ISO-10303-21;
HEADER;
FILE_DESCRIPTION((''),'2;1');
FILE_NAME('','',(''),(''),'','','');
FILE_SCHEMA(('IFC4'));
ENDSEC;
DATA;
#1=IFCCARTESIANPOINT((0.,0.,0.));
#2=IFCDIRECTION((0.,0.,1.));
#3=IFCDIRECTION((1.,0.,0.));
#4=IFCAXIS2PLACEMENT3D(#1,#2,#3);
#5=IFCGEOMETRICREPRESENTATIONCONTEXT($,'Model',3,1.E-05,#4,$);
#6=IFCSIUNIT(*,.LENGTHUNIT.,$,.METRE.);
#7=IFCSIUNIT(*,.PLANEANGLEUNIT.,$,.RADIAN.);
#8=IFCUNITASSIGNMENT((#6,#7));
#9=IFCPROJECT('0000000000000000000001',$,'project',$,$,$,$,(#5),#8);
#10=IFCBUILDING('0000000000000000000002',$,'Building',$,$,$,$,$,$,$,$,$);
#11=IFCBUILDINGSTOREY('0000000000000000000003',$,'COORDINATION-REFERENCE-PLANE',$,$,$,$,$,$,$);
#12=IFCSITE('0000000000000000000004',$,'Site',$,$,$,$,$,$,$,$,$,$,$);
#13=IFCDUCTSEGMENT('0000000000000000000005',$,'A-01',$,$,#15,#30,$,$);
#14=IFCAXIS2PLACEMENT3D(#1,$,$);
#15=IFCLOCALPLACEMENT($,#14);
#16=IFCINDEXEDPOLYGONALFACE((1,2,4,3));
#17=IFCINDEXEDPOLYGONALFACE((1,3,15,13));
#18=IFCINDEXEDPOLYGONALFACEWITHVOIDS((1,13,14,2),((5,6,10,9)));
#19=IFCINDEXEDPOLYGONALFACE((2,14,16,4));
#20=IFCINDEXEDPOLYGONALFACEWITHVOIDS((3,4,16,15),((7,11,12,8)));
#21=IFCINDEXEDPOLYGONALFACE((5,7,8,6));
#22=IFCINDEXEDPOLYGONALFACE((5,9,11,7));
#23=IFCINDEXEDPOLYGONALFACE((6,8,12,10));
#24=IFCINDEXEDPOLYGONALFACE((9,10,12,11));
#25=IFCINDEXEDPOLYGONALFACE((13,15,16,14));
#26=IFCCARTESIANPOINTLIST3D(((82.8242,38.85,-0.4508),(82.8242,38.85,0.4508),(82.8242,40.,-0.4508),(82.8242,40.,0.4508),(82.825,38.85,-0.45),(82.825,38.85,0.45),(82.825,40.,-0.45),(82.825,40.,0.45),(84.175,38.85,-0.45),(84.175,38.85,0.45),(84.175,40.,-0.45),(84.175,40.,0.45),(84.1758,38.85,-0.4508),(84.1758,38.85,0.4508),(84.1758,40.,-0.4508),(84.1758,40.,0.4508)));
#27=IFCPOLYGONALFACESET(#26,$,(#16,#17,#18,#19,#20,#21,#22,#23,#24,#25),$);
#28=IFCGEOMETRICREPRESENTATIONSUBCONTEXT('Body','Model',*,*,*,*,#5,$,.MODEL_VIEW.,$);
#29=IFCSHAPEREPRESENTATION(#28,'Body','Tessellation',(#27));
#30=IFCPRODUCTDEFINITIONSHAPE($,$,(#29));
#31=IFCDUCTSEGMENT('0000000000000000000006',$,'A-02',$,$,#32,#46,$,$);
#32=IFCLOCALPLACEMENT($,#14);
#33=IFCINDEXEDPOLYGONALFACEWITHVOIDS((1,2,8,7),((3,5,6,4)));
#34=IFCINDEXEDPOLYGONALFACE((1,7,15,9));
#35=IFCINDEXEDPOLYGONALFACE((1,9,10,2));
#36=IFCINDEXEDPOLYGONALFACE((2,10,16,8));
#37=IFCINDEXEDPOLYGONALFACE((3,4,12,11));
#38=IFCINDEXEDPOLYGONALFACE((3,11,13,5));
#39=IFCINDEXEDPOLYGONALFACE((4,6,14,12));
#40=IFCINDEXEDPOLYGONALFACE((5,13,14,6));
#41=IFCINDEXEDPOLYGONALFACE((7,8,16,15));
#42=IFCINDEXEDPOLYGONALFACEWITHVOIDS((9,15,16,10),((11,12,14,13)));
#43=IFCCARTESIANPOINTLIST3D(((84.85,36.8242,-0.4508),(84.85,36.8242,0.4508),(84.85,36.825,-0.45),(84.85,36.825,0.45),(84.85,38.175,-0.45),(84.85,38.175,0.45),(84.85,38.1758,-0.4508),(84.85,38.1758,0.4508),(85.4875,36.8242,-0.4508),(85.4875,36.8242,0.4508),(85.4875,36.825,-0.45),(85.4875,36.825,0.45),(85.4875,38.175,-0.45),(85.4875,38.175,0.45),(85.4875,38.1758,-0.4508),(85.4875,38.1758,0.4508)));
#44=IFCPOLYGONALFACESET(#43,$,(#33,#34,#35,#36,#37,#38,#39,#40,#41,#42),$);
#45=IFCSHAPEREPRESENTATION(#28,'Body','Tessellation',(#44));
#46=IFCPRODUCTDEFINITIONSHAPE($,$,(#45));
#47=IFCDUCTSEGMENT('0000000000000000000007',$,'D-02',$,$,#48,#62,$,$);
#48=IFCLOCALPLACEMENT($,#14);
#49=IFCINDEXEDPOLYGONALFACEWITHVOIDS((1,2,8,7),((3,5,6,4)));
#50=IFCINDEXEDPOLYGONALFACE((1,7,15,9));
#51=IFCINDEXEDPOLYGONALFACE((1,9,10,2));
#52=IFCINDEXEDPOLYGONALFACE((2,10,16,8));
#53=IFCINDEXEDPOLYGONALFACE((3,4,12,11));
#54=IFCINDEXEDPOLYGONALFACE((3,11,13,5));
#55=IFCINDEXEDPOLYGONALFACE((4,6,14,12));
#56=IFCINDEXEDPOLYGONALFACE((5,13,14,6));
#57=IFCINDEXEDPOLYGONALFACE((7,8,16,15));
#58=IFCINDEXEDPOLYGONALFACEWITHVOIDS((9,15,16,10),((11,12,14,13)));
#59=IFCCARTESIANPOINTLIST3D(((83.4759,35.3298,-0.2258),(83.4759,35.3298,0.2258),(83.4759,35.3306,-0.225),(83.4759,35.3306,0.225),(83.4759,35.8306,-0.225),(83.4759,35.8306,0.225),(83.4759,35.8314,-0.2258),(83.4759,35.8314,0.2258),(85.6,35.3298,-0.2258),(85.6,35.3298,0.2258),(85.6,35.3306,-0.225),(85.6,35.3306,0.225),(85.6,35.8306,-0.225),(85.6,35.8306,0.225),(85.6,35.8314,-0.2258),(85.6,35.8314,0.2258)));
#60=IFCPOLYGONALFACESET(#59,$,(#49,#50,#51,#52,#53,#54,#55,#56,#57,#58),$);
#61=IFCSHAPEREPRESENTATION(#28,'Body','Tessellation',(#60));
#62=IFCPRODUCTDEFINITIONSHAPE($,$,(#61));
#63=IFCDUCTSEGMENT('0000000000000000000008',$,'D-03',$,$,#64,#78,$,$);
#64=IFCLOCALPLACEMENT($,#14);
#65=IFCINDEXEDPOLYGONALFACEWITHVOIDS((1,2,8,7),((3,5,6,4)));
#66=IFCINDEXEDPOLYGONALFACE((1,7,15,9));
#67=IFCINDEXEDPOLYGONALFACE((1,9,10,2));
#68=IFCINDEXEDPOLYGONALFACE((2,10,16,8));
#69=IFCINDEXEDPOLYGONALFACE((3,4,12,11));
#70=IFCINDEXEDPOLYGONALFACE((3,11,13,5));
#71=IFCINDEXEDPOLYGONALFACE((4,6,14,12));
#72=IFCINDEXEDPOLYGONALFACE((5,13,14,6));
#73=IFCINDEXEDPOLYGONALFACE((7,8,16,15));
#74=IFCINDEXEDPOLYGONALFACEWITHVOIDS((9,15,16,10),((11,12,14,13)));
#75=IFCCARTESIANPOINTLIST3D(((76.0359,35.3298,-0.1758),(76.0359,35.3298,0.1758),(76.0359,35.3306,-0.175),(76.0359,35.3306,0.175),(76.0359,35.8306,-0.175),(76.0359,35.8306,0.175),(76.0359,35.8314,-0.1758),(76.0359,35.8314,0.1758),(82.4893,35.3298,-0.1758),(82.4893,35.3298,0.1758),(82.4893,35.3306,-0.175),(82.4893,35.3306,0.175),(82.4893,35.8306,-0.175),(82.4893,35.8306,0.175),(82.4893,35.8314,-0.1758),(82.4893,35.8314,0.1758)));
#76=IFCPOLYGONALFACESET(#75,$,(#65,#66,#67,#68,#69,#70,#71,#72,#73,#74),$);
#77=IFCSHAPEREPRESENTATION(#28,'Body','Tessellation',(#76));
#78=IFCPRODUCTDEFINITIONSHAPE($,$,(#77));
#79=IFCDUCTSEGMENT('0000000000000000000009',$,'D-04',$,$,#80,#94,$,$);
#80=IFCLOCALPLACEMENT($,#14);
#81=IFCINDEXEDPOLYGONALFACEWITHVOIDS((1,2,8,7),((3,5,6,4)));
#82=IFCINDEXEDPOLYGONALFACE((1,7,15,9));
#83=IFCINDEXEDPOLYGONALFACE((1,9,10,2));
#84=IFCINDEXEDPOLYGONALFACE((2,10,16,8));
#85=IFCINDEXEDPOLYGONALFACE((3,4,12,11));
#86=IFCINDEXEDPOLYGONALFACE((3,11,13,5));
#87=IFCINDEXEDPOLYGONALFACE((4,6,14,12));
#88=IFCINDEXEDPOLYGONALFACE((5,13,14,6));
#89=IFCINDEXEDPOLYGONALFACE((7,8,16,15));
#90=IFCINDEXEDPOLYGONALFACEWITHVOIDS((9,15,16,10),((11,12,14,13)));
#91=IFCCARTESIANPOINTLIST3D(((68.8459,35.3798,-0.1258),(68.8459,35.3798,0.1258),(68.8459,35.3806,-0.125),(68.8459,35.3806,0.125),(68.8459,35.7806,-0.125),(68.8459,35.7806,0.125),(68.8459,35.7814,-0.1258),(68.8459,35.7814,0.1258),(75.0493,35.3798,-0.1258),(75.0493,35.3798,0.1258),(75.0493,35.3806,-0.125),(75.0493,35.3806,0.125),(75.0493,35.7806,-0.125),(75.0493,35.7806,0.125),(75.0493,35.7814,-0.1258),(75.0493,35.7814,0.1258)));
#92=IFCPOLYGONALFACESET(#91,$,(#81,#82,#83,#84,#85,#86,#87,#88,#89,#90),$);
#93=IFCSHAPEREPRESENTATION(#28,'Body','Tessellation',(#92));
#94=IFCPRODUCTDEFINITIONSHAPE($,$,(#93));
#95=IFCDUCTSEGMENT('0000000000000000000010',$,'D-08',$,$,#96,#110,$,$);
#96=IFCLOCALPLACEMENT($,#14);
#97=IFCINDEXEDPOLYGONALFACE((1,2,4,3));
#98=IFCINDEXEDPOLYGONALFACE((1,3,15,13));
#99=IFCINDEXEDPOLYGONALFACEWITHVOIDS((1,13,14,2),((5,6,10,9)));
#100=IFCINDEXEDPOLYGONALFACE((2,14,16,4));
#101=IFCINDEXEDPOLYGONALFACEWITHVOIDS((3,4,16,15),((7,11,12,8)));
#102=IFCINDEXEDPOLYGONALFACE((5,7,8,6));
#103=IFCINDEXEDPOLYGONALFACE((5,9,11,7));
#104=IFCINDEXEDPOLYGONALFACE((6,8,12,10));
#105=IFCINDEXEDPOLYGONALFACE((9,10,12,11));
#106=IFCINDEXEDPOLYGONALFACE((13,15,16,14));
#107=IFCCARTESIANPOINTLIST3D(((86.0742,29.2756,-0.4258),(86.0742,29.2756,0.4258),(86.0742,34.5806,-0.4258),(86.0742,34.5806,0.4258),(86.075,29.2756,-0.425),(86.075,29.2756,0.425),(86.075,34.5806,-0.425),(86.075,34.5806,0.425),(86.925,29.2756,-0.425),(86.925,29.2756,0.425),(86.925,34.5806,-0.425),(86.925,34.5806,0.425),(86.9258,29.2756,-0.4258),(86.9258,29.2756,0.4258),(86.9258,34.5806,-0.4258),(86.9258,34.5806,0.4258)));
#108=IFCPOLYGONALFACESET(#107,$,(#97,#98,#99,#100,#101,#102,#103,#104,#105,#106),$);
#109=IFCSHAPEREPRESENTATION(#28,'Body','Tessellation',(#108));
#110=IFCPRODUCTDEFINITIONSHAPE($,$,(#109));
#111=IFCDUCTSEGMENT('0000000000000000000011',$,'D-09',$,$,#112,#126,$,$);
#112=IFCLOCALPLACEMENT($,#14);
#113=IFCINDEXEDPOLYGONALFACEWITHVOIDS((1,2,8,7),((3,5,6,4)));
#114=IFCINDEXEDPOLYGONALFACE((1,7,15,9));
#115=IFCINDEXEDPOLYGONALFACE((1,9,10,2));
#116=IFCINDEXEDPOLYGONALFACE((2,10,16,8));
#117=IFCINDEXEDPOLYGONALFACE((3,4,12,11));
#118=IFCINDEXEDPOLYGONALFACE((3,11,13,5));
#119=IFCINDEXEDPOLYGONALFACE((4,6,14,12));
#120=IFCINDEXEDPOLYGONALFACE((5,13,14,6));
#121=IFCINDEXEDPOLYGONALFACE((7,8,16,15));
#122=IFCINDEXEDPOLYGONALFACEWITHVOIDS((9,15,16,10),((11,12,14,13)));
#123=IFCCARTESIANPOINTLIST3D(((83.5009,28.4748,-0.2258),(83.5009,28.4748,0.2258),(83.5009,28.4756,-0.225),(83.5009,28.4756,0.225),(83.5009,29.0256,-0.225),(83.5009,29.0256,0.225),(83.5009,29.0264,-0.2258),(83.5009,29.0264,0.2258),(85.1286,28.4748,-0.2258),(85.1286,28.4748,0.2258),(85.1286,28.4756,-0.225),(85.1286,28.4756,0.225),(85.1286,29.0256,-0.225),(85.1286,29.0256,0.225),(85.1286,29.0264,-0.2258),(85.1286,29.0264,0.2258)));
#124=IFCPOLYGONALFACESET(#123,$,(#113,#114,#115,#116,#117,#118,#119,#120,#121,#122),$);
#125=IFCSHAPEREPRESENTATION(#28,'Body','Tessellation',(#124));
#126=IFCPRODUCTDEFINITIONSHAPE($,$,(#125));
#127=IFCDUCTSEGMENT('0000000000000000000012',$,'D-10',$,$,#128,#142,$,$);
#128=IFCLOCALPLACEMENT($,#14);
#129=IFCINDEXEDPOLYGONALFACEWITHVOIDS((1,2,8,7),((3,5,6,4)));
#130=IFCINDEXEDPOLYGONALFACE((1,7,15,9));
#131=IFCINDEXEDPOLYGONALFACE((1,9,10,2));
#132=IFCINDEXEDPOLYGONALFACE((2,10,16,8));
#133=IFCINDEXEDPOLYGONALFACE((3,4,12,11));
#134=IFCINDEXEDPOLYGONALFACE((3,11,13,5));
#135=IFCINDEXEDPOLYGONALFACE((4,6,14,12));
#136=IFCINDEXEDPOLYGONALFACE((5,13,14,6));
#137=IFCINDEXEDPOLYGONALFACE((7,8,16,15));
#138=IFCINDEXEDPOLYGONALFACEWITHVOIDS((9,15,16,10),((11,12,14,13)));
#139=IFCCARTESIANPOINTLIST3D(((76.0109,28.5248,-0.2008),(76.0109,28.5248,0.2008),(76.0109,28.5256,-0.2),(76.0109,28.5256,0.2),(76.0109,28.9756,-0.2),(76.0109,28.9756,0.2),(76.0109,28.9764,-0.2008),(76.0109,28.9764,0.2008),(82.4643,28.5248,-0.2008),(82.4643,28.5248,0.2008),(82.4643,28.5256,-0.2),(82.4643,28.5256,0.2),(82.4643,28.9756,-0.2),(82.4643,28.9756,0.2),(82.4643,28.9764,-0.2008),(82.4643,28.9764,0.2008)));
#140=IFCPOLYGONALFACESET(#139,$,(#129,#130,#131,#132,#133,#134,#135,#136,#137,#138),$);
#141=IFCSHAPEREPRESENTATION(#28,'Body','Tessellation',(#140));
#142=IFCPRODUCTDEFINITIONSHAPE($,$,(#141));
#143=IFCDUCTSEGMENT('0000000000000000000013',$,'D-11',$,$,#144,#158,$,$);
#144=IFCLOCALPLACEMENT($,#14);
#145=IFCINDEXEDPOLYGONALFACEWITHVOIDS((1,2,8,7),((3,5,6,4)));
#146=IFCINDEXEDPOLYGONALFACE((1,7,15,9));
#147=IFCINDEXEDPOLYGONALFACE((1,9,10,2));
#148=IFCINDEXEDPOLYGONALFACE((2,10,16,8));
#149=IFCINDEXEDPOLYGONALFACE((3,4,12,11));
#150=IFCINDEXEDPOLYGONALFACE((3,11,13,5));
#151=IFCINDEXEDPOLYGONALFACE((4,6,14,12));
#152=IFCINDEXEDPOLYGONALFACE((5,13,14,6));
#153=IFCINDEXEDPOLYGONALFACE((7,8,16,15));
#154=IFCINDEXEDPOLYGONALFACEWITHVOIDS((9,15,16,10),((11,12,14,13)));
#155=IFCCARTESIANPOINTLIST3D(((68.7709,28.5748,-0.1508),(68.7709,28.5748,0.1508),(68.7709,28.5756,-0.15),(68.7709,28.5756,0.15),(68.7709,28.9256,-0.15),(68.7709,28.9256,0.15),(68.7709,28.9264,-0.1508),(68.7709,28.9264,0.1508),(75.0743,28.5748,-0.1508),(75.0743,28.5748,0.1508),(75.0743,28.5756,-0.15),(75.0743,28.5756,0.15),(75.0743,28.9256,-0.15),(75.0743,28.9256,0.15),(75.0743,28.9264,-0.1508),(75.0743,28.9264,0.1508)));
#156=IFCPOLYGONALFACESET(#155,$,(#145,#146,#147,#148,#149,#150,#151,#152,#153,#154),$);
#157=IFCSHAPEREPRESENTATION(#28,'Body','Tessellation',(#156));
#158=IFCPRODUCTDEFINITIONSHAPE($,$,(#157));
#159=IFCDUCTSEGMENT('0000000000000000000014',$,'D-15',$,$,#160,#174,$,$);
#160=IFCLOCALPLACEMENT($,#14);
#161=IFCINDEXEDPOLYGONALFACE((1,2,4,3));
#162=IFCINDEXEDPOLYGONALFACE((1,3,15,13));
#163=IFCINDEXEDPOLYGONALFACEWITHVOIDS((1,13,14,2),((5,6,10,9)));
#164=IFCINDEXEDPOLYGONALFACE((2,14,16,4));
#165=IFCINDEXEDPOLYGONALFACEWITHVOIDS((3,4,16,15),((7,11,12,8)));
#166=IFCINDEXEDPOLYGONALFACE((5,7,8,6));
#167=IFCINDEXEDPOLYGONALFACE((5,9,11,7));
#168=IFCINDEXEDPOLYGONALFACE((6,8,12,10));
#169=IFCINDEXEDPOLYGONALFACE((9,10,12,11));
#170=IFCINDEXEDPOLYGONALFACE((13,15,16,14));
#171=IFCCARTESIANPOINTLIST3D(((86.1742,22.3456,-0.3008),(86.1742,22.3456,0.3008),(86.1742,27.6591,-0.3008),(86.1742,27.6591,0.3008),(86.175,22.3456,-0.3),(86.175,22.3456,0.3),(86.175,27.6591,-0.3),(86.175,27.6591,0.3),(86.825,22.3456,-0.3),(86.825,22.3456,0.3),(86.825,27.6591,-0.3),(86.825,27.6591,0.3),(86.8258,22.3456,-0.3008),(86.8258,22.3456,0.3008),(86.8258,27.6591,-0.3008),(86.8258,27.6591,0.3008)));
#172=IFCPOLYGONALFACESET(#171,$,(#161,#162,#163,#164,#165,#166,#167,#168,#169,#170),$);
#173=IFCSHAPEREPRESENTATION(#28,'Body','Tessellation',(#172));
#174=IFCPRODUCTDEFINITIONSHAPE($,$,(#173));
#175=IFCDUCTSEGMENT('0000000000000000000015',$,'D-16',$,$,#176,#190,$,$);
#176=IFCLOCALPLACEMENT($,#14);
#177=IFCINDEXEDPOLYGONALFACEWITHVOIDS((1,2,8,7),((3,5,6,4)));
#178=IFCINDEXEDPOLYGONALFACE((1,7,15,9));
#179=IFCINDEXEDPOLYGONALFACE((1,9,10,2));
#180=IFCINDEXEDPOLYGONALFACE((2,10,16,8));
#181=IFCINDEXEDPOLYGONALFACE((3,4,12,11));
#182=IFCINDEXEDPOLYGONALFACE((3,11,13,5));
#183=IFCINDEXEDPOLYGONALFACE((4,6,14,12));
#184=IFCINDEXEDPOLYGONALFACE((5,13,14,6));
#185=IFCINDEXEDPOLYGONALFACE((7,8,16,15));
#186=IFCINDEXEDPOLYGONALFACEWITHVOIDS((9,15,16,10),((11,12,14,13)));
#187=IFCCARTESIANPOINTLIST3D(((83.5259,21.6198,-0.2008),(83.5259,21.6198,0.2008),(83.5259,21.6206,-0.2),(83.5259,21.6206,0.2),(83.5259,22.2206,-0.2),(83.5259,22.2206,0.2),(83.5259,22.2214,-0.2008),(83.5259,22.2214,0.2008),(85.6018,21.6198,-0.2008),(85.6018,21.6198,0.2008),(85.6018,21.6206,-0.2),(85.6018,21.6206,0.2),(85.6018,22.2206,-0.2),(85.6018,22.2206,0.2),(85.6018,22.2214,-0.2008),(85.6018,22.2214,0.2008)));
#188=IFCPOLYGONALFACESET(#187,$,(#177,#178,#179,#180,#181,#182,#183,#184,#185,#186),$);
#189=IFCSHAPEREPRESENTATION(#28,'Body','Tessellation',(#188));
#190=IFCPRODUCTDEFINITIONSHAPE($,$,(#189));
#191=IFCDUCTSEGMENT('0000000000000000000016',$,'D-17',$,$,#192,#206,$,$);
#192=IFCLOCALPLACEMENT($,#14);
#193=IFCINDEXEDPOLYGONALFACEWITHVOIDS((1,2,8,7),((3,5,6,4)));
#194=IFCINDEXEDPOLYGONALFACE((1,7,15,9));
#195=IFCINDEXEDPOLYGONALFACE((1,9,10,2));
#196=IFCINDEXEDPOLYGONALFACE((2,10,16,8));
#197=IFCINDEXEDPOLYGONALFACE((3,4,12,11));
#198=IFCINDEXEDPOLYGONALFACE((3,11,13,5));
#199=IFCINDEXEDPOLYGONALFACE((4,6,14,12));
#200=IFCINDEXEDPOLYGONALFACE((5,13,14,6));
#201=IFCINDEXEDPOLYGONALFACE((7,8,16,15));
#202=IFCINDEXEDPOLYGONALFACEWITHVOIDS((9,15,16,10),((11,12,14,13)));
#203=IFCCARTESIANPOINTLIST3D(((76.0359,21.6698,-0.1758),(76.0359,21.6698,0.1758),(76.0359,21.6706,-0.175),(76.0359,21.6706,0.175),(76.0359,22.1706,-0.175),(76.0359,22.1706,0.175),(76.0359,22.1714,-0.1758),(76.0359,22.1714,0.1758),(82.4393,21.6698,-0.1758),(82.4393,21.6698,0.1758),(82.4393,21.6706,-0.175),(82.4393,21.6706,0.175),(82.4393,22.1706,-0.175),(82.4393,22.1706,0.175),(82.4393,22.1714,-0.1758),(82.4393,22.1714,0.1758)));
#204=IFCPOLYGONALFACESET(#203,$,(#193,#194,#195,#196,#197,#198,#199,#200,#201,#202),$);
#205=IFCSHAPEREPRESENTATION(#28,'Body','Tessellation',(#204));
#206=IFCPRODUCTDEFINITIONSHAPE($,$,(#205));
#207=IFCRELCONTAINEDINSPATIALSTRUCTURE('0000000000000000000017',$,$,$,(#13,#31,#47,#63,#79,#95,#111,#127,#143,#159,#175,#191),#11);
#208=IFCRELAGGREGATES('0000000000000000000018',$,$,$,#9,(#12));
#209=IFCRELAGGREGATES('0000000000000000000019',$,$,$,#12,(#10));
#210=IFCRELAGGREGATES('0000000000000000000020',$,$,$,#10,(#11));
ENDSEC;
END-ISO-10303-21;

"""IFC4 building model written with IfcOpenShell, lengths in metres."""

from ifc_helpers import new_model, si_unit, frame, origin, origin_with_axes, place, context, subcontext, project, spatial, hollow_rectangle, extrude, element, save


model = new_model("IFC4")

# Units and contexts
model_context = context("Model", 3, precision=1e-05, world=origin_with_axes())
body_context = subcontext(model_context, "Body", "Model", "MODEL_VIEW")
ifc_project = project(units=[si_unit("LENGTHUNIT", "METRE"), si_unit("PLANEANGLEUNIT", "RADIAN")], contexts=[model_context])

# Site, building, storey
site = spatial("IfcSite", under=ifc_project, Name="Site")
building = spatial("IfcBuilding", under=site, Name="Building")
storey = spatial("IfcBuildingStorey", under=building, Name="COORDINATION-REFERENCE-PLANE")

# Duct segments
duct_segment_1_placement = place(None, frame((83.5, 38.85, 0.0), z_axis=(0.0, 1.0, 0.0), x_axis=(1.0, 0.0, 0.0)))
element("IfcDuctSegment", 1, at=duct_segment_1_placement, inside=storey, Name="A-01", context=body_context, shape_type="SweptSolid", body=[
    extrude(hollow_rectangle(XDim=1.3516, YDim=0.9016, WallThickness=0.0008), origin(), (0.0, 0.0, 1.0), 1.15),
])
duct_segment_2_placement = place(None, frame((84.85, 37.5, 0.0), z_axis=(1.0, 0.0, 0.0), x_axis=(0.0, 1.0, 0.0)))
element("IfcDuctSegment", 2, at=duct_segment_2_placement, inside=storey, Name="A-02", context=body_context, shape_type="SweptSolid", body=[
    extrude(hollow_rectangle(XDim=1.3516, YDim=0.9016, WallThickness=0.0008), origin(), (0.0, 0.0, 1.0), 0.6375),
])
duct_segment_3_placement = place(None, frame((83.4759, 35.5806, 0.0), z_axis=(1.0, 0.0, 0.0), x_axis=(0.0, 1.0, 0.0)))
element("IfcDuctSegment", 3, at=duct_segment_3_placement, inside=storey, Name="D-02", context=body_context, shape_type="SweptSolid", body=[
    extrude(hollow_rectangle(XDim=0.5016, YDim=0.4516, WallThickness=0.0008), origin(), (0.0, 0.0, 1.0), 2.1241),
])
duct_segment_4_placement = place(None, frame((76.0359, 35.5806, 0.0), z_axis=(1.0, 0.0, 0.0), x_axis=(0.0, 1.0, 0.0)))
element("IfcDuctSegment", 4, at=duct_segment_4_placement, inside=storey, Name="D-03", context=body_context, shape_type="SweptSolid", body=[
    extrude(hollow_rectangle(XDim=0.5016, YDim=0.3516, WallThickness=0.0008), origin(), (0.0, 0.0, 1.0), 6.4534),
])
duct_segment_5_placement = place(None, frame((68.8459, 35.5806, 0.0), z_axis=(1.0, 0.0, 0.0), x_axis=(0.0, 1.0, 0.0)))
element("IfcDuctSegment", 5, at=duct_segment_5_placement, inside=storey, Name="D-04", context=body_context, shape_type="SweptSolid", body=[
    extrude(hollow_rectangle(XDim=0.4016, YDim=0.2516, WallThickness=0.0008), origin(), (0.0, 0.0, 1.0), 6.2034),
])
duct_segment_6_placement = place(None, frame((86.5, 29.2756, 0.0), z_axis=(0.0, 1.0, 0.0), x_axis=(1.0, 0.0, 0.0)))
element("IfcDuctSegment", 6, at=duct_segment_6_placement, inside=storey, Name="D-08", context=body_context, shape_type="SweptSolid", body=[
    extrude(hollow_rectangle(XDim=0.8516, YDim=0.8516, WallThickness=0.0008), origin(), (0.0, 0.0, 1.0), 5.305),
])
duct_segment_7_placement = place(None, frame((83.5009, 28.7506, 0.0), z_axis=(1.0, 0.0, 0.0), x_axis=(0.0, 1.0, 0.0)))
element("IfcDuctSegment", 7, at=duct_segment_7_placement, inside=storey, Name="D-09", context=body_context, shape_type="SweptSolid", body=[
    extrude(hollow_rectangle(XDim=0.5516, YDim=0.4516, WallThickness=0.0008), origin(), (0.0, 0.0, 1.0), 1.6277),
])
duct_segment_8_placement = place(None, frame((76.0109, 28.7506, 0.0), z_axis=(1.0, 0.0, 0.0), x_axis=(0.0, 1.0, 0.0)))
element("IfcDuctSegment", 8, at=duct_segment_8_placement, inside=storey, Name="D-10", context=body_context, shape_type="SweptSolid", body=[
    extrude(hollow_rectangle(XDim=0.4516, YDim=0.4016, WallThickness=0.0008), origin(), (0.0, 0.0, 1.0), 6.4534),
])
duct_segment_9_placement = place(None, frame((68.7709, 28.7506, 0.0), z_axis=(1.0, 0.0, 0.0), x_axis=(0.0, 1.0, 0.0)))
element("IfcDuctSegment", 9, at=duct_segment_9_placement, inside=storey, Name="D-11", context=body_context, shape_type="SweptSolid", body=[
    extrude(hollow_rectangle(XDim=0.3516, YDim=0.3016, WallThickness=0.0008), origin(), (0.0, 0.0, 1.0), 6.3034),
])
duct_segment_10_placement = place(None, frame((86.5, 22.3456, 0.0), z_axis=(0.0, 1.0, 0.0), x_axis=(1.0, 0.0, 0.0)))
element("IfcDuctSegment", 10, at=duct_segment_10_placement, inside=storey, Name="D-15", context=body_context, shape_type="SweptSolid", body=[
    extrude(hollow_rectangle(XDim=0.6516, YDim=0.6016, WallThickness=0.0008), origin(), (0.0, 0.0, 1.0), 5.3135),
])
duct_segment_11_placement = place(None, frame((83.5259, 21.9206, 0.0), z_axis=(1.0, 0.0, 0.0), x_axis=(0.0, 1.0, 0.0)))
element("IfcDuctSegment", 11, at=duct_segment_11_placement, inside=storey, Name="D-16", context=body_context, shape_type="SweptSolid", body=[
    extrude(hollow_rectangle(XDim=0.6016, YDim=0.4016, WallThickness=0.0008), origin(), (0.0, 0.0, 1.0), 2.0759),
])
duct_segment_12_placement = place(None, frame((76.0359, 21.9206, 0.0), z_axis=(1.0, 0.0, 0.0), x_axis=(0.0, 1.0, 0.0)))
element("IfcDuctSegment", 12, at=duct_segment_12_placement, inside=storey, Name="D-17", context=body_context, shape_type="SweptSolid", body=[
    extrude(hollow_rectangle(XDim=0.5016, YDim=0.3516, WallThickness=0.0008), origin(), (0.0, 0.0, 1.0), 6.4034),
])

save(model, "model.ifc")
